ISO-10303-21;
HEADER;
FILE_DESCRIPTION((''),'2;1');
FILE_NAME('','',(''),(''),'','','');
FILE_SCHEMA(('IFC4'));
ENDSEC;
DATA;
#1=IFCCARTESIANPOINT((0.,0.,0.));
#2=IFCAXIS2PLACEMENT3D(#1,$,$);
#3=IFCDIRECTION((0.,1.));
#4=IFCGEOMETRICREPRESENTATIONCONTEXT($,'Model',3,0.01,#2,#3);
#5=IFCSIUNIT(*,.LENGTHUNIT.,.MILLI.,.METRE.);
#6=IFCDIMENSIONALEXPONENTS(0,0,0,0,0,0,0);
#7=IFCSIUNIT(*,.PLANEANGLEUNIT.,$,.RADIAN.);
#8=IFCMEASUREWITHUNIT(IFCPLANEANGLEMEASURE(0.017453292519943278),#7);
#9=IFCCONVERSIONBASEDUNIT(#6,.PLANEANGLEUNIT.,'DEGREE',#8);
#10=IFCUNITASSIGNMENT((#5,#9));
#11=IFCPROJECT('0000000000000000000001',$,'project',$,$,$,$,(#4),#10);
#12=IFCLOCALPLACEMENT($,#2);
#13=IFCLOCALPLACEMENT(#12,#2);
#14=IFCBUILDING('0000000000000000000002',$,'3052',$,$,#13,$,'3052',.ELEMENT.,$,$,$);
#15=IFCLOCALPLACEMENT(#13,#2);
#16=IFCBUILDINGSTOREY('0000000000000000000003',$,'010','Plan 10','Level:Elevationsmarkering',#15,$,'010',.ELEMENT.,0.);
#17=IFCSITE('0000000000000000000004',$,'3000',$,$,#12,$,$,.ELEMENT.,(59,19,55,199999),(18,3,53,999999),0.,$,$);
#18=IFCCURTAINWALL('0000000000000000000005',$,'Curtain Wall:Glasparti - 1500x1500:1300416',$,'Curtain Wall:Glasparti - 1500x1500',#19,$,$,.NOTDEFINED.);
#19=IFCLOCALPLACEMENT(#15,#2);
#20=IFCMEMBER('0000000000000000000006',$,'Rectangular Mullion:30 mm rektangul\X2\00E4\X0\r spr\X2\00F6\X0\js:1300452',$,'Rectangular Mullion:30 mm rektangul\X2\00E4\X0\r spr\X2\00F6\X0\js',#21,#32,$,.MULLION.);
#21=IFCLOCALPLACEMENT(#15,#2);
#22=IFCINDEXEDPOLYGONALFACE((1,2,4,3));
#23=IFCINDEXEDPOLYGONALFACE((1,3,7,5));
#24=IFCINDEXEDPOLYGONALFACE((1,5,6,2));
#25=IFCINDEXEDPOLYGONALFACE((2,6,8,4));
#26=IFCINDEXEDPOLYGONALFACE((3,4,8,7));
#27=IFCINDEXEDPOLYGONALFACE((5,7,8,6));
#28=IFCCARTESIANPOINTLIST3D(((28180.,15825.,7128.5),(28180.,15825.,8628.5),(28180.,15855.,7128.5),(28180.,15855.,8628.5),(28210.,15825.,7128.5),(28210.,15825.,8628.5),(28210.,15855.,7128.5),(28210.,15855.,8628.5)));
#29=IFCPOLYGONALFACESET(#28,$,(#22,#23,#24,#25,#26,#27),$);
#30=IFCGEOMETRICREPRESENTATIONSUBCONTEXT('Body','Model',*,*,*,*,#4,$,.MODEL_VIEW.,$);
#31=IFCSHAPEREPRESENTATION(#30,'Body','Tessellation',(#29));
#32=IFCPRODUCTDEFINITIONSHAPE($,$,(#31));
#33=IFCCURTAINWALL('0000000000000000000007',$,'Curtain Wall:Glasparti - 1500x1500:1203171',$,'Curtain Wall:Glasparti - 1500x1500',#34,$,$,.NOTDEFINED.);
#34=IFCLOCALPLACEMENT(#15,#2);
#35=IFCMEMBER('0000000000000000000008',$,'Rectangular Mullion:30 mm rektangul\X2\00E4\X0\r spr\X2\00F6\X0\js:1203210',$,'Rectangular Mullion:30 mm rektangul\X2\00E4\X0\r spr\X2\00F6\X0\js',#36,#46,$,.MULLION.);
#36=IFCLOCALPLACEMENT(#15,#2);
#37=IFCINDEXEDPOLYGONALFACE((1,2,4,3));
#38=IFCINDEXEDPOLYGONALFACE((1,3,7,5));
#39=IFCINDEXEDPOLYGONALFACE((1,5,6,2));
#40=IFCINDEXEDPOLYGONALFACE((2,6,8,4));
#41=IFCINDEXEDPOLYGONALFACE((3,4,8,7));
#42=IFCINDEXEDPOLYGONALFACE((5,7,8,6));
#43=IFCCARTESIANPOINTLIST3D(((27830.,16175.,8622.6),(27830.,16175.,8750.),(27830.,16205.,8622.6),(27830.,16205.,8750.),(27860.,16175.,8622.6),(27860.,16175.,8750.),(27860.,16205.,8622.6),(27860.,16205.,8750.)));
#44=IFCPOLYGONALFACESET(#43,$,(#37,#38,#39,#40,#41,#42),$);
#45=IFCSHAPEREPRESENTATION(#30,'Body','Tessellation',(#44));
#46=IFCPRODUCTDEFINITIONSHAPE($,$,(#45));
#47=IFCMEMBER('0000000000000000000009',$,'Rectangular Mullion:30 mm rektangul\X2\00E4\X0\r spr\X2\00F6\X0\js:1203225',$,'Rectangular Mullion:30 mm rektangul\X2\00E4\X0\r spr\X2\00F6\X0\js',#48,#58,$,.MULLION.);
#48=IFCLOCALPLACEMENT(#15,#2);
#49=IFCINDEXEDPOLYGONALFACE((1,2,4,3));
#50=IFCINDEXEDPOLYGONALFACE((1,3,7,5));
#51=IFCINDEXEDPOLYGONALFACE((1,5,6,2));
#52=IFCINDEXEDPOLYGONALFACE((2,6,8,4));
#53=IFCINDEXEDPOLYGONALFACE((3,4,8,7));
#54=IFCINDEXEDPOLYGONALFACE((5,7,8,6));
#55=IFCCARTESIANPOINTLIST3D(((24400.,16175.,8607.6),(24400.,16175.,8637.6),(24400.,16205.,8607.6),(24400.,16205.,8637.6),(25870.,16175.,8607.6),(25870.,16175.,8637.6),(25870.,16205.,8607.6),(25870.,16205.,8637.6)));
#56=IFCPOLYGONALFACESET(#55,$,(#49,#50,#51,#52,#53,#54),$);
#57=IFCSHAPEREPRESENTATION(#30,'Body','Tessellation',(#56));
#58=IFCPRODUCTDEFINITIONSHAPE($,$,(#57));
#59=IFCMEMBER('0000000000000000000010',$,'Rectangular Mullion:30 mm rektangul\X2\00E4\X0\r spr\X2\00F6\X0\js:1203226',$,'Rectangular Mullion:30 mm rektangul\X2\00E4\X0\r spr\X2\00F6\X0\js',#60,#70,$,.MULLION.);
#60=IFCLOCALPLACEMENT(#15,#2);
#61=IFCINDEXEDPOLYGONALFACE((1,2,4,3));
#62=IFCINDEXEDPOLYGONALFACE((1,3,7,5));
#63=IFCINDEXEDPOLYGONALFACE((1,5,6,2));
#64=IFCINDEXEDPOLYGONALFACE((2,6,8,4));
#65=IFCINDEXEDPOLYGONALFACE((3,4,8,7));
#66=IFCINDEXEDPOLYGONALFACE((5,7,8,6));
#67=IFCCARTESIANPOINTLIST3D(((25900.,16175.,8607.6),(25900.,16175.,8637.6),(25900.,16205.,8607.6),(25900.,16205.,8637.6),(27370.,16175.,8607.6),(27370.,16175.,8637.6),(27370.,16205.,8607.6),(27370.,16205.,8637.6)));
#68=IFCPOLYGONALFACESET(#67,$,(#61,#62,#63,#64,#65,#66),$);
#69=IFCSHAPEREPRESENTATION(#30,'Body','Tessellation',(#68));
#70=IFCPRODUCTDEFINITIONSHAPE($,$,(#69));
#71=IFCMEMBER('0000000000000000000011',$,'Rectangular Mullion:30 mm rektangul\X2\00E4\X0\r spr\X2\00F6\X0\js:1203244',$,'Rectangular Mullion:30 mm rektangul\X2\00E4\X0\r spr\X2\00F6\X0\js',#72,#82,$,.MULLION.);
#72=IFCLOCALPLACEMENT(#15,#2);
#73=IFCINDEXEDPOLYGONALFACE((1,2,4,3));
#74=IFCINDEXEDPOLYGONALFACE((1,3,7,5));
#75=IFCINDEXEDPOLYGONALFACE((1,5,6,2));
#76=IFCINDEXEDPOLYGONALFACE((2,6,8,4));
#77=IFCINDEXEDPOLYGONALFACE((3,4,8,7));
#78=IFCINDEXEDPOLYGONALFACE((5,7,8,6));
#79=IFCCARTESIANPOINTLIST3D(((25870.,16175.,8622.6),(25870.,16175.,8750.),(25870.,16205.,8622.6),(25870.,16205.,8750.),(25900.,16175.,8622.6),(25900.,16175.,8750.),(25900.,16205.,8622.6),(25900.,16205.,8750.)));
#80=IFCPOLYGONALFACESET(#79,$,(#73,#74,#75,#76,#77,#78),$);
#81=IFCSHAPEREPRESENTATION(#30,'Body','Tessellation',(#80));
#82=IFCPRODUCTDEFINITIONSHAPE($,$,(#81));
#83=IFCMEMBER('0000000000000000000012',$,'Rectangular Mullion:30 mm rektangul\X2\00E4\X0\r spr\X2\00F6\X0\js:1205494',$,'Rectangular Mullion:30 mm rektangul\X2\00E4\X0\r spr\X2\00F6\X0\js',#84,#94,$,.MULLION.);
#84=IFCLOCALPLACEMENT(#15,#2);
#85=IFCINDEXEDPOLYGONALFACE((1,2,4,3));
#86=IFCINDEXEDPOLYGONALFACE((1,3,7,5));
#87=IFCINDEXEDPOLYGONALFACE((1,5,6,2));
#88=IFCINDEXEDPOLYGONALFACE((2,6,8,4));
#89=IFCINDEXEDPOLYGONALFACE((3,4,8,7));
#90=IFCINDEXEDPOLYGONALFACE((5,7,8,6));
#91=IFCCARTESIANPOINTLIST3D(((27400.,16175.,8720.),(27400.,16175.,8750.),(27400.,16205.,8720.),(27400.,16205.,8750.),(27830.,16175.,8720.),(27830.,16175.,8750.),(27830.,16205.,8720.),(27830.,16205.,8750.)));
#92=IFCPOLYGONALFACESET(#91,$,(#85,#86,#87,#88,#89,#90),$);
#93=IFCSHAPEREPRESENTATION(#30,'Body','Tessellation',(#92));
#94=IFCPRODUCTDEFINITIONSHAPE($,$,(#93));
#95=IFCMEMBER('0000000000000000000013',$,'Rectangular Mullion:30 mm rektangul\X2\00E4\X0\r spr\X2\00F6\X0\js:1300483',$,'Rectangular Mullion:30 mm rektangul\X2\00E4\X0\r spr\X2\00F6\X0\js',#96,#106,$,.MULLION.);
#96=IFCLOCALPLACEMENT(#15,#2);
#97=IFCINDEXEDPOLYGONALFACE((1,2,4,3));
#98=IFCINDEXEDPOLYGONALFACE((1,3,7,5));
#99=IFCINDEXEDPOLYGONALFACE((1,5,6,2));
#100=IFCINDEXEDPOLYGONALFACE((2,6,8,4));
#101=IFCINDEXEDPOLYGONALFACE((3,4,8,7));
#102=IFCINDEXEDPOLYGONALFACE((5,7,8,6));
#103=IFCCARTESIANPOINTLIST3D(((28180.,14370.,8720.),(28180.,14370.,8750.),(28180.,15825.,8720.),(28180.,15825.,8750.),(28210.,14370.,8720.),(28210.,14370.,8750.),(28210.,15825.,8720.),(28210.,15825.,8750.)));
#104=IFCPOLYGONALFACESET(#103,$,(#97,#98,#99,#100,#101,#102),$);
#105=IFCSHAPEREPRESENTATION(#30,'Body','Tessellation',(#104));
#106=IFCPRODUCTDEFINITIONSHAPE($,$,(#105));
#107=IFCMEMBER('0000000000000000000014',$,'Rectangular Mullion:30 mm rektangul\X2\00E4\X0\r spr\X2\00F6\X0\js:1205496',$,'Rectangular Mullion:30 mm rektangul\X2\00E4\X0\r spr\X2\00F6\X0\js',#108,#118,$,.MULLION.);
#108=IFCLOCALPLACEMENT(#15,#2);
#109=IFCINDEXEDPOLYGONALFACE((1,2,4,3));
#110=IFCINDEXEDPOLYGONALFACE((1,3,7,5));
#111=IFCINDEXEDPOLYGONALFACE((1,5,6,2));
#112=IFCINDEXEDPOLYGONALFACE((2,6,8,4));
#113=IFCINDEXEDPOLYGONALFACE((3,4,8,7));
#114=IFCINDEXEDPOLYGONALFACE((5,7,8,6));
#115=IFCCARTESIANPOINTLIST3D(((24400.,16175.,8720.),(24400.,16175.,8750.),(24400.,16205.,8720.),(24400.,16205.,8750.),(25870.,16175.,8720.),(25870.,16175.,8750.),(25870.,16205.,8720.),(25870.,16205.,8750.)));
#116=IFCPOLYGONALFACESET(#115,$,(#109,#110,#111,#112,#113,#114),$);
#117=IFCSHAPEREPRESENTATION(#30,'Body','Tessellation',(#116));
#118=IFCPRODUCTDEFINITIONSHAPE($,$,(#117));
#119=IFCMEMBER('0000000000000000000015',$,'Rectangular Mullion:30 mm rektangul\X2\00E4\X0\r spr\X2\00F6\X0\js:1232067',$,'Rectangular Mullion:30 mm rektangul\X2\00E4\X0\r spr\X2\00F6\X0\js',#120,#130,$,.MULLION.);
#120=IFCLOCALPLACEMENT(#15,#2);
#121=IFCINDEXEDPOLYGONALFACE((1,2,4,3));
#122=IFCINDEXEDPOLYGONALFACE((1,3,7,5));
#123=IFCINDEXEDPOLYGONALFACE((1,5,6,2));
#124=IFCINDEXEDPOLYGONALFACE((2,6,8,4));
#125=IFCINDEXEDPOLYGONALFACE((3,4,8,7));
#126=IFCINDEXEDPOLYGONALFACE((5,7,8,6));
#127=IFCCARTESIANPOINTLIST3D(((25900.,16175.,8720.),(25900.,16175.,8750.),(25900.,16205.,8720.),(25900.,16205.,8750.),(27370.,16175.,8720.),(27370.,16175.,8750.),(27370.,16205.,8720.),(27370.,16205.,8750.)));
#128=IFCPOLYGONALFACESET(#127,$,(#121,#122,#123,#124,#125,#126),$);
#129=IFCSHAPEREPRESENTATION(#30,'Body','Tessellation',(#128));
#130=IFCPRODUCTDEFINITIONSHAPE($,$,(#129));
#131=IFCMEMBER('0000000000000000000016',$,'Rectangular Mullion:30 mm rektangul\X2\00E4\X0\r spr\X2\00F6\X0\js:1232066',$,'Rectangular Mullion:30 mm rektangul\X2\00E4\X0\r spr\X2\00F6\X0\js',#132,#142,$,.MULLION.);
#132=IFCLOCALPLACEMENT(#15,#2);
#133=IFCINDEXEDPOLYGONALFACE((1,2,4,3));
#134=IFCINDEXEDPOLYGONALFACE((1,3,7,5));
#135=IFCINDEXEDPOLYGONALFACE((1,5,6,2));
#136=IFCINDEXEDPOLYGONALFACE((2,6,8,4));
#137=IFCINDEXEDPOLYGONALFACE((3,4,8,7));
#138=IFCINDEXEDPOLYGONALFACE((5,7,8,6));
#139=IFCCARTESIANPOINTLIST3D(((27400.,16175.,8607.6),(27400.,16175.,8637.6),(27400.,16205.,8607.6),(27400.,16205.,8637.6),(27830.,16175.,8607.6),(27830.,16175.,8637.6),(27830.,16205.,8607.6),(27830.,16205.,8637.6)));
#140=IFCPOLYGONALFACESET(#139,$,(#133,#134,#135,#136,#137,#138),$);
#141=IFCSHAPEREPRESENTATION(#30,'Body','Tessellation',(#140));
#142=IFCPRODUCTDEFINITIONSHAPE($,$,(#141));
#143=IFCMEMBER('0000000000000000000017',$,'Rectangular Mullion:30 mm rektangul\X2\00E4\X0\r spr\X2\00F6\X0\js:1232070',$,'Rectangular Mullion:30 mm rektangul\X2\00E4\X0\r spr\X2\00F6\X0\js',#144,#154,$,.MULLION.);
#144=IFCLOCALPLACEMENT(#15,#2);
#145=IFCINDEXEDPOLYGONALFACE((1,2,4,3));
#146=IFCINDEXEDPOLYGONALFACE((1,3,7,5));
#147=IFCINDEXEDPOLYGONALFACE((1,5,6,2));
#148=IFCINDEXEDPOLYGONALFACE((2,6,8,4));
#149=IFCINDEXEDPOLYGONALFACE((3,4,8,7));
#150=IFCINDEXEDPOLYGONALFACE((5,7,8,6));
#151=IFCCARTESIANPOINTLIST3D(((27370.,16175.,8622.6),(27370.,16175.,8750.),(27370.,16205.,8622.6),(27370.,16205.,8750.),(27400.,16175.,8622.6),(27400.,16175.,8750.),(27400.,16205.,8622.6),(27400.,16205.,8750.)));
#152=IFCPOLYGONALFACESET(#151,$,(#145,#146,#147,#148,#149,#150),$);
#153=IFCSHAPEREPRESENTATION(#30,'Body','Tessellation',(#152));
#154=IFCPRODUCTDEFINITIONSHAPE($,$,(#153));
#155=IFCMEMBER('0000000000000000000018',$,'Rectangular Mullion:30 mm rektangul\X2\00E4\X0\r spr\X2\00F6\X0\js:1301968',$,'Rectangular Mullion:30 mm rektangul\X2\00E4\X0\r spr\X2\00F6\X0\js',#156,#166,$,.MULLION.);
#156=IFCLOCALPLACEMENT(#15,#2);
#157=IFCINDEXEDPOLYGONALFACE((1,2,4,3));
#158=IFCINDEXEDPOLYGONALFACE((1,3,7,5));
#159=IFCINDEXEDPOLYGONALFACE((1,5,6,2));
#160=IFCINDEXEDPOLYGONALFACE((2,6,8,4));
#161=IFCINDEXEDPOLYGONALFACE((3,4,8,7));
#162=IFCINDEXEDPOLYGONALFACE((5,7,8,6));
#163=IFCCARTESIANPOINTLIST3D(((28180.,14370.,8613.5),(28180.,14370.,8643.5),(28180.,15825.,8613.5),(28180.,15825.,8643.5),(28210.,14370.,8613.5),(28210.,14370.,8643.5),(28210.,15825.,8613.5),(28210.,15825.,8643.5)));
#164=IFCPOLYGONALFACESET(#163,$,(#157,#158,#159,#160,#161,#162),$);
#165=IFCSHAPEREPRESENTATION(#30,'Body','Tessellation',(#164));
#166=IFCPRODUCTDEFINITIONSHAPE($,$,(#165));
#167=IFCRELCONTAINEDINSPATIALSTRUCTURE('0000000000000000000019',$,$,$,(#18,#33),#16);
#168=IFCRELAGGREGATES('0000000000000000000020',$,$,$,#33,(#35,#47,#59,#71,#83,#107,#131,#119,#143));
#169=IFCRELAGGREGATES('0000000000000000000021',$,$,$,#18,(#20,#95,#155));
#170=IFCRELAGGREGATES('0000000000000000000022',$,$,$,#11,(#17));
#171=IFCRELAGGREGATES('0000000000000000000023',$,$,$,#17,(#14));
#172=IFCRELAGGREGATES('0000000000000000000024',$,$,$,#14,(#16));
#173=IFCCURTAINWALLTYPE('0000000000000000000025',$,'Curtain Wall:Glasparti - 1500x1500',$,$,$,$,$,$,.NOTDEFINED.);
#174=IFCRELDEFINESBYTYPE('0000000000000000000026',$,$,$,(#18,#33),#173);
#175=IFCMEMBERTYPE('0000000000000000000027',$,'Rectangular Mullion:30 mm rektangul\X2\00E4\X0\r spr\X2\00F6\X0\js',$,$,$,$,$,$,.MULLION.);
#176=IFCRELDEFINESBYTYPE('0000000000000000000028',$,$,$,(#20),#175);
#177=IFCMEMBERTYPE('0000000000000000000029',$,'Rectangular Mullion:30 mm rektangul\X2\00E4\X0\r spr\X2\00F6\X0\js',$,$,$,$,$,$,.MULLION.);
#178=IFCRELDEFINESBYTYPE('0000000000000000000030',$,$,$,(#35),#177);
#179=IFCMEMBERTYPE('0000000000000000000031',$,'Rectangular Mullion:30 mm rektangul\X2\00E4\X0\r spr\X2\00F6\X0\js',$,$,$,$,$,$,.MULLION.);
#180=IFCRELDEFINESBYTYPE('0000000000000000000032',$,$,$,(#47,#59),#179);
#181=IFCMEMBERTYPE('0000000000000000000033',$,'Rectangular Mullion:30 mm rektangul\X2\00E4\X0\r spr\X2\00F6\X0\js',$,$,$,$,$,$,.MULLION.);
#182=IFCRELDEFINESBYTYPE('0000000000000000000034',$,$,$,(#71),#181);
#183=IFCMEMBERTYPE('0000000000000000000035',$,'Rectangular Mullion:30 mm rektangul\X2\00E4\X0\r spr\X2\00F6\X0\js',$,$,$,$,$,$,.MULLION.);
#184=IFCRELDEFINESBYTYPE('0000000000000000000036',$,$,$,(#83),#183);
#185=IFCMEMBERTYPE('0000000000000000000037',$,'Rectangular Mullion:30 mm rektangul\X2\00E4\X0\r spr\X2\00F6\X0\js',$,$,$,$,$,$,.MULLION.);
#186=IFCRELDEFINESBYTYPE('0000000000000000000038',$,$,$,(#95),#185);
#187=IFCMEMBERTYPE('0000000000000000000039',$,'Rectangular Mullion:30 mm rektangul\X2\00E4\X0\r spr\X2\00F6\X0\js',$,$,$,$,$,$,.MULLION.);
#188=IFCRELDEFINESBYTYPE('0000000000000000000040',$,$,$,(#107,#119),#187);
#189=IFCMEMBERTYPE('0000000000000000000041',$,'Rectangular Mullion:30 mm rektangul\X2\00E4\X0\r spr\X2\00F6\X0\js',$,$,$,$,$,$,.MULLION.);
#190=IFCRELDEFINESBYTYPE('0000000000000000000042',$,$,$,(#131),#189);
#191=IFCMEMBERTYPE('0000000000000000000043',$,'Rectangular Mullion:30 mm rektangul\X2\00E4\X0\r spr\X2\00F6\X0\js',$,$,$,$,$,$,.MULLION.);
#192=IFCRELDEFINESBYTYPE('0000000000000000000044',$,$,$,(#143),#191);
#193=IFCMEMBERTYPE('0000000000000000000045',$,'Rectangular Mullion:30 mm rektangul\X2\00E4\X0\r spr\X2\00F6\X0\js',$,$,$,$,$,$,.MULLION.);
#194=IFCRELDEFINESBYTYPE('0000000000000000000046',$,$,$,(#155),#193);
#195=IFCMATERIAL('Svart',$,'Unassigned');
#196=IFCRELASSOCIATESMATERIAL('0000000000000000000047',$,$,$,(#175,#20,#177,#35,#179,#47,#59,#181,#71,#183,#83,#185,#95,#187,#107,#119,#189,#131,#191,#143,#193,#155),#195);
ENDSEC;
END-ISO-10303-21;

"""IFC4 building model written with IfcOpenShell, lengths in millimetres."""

from ifc_helpers import new_model, entity, si_unit, converted_unit, direction, frame, origin, place, context, subcontext, project, spatial, indexed_curve, outline, extrude, source, transform, mapped, material, type_object, type_shapes, element, aggregate, save


model = new_model("IFC4")

# Units and contexts
model_context = context("Model", 3, precision=0.01, world=origin(), true_north=direction((0.0, 1.0)))
body_context = subcontext(model_context, "Body", "Model", "MODEL_VIEW")
ifc_project = project(units=[si_unit("LENGTHUNIT", "METRE", prefix="MILLI"), converted_unit("PLANEANGLEUNIT", "DEGREE", entity("IfcPlaneAngleMeasure", 0.017453292519943278), si_unit("PLANEANGLEUNIT", "RADIAN"), dimensions=[0, 0, 0, 0, 0, 0, 0])], contexts=[model_context])

# Site, building, storey
site_placement = place(None, origin())
site = spatial("IfcSite", under=ifc_project, at=site_placement, Name="3000", CompositionType="ELEMENT", RefLatitude=(59, 19, 55, 199999), RefLongitude=(18, 3, 53, 999999), RefElevation=0.0)
building_placement = place(site_placement, origin())
building = spatial("IfcBuilding", under=site, at=building_placement, Name="3052", LongName="3052", CompositionType="ELEMENT")
storey_placement = place(building_placement, origin())
storey = spatial("IfcBuildingStorey", under=building, at=storey_placement, Name="010", Description="Plan 10", ObjectType="Level:Elevationsmarkering", LongName="010", CompositionType="ELEMENT", Elevation=0.0)

# Curtain wall, member
curtain_wall_type = type_object("IfcCurtainWallType", Name="Curtain Wall:Glasparti - 1500x1500", PredefinedType="NOTDEFINED")
curtain_wall_1_placement = place(storey_placement, origin())
curtain_wall_1 = element("IfcCurtainWall", 1, at=curtain_wall_1_placement, inside=storey, type_object=curtain_wall_type, Name="Curtain Wall:Glasparti - 1500x1500:1300416", ObjectType="Curtain Wall:Glasparti - 1500x1500", PredefinedType="NOTDEFINED")
ifc_material_1 = material(Name="Svart", Category="Unassigned")
member_type_1 = type_object("IfcMemberType", Name="Rectangular Mullion:30 mm rektangulär spröjs", PredefinedType="MULLION", material=ifc_material_1)
shared_shape_1 = source(origin(), body_context, "Body", "SweptSolid", [
    extrude(outline(indexed_curve([(-15.0, -15.0), (15.0, -15.0), (15.0, 15.0), (-15.0, 15.0), (-15.0, -15.0)], self_intersect=False)), frame((-15.0, 0.0, -1500.0), z_axis=(0.0, 0.0, 1.0), x_axis=(-1.0, 0.0, 0.0)), (0.0, 0.0, 1.0), 1500.0),
])
type_shapes(member_type_1, [shared_shape_1])
member_1_placement = place(curtain_wall_1_placement, frame((28195.0, 15855.0, 8628.5), z_axis=(0.0, 0.0, 1.0), x_axis=(0.0, 1.0, 0.0)))
member_1 = element("IfcMember", 2, at=member_1_placement, type_object=member_type_1, material=ifc_material_1, Name="Rectangular Mullion:30 mm rektangulär spröjs:1300452", ObjectType="Rectangular Mullion:30 mm rektangulär spröjs", PredefinedType="MULLION", context=body_context, shape_type="MappedRepresentation", body=[
    mapped(shared_shape_1, transform((0.0, 0.0, 0.0), scale=1.0)),
])

# Curtain wall, members
curtain_wall_2_placement = place(storey_placement, origin())
curtain_wall_2 = element("IfcCurtainWall", 3, at=curtain_wall_2_placement, inside=storey, type_object=curtain_wall_type, Name="Curtain Wall:Glasparti - 1500x1500:1203171", ObjectType="Curtain Wall:Glasparti - 1500x1500", PredefinedType="NOTDEFINED")
member_type_2 = type_object("IfcMemberType", Name="Rectangular Mullion:30 mm rektangulär spröjs", PredefinedType="MULLION", material=ifc_material_1)
shared_shape_2 = source(origin(), body_context, "Body", "SweptSolid", [
    extrude(outline(indexed_curve([(-15.0, -15.0), (15.0, -15.0), (15.0, 15.0), (-15.0, 15.0), (-15.0, -15.0)], self_intersect=False)), frame((-15.0, 0.0, -127.4), z_axis=(0.0, 0.0, 1.0), x_axis=(-1.0, 0.0, 0.0)), (0.0, 0.0, 1.0), 127.4),
])
type_shapes(member_type_2, [shared_shape_2])
member_2_placement = place(curtain_wall_2_placement, frame((27860.0, 16190.0, 8622.6), z_axis=(0.0, 0.0, -1.0), x_axis=(1.0, 0.0, 0.0)))
member_2 = element("IfcMember", 4, at=member_2_placement, type_object=member_type_2, material=ifc_material_1, Name="Rectangular Mullion:30 mm rektangulär spröjs:1203210", ObjectType="Rectangular Mullion:30 mm rektangulär spröjs", PredefinedType="MULLION", context=body_context, shape_type="MappedRepresentation", body=[
    mapped(shared_shape_2, transform((0.0, 0.0, 0.0), scale=1.0)),
])
member_type_3 = type_object("IfcMemberType", Name="Rectangular Mullion:30 mm rektangulär spröjs", PredefinedType="MULLION", material=ifc_material_1)
shared_shape_3 = source(origin(), body_context, "Body", "SweptSolid", [
    extrude(outline(indexed_curve([(-15.0, -15.0), (15.0, -15.0), (15.0, 15.0), (-15.0, 15.0), (-15.0, -15.0)], self_intersect=False)), frame((0.0, 0.0, -1470.0), z_axis=(0.0, 0.0, 1.0), x_axis=(-1.0, 0.0, 0.0)), (0.0, 0.0, 1.0), 1470.0),
])
type_shapes(member_type_3, [shared_shape_3])
member_3_placement = place(curtain_wall_2_placement, frame((25870.0, 16190.0, 8622.6), z_axis=(1.0, 0.0, 0.0), x_axis=(0.0, 0.0, 1.0)))
member_3 = element("IfcMember", 5, at=member_3_placement, type_object=member_type_3, material=ifc_material_1, Name="Rectangular Mullion:30 mm rektangulär spröjs:1203225", ObjectType="Rectangular Mullion:30 mm rektangulär spröjs", PredefinedType="MULLION", context=body_context, shape_type="MappedRepresentation", body=[
    mapped(shared_shape_3, transform((0.0, 0.0, 0.0), scale=1.0)),
])
member_4_placement = place(curtain_wall_2_placement, frame((27370.0, 16190.0, 8622.6), z_axis=(1.0, 0.0, 0.0), x_axis=(0.0, 0.0, 1.0)))
member_4 = element("IfcMember", 6, at=member_4_placement, type_object=member_type_3, material=ifc_material_1, Name="Rectangular Mullion:30 mm rektangulär spröjs:1203226", ObjectType="Rectangular Mullion:30 mm rektangulär spröjs", PredefinedType="MULLION", context=body_context, shape_type="MappedRepresentation", body=[
    mapped(shared_shape_3, transform((0.0, 0.0, 0.0), scale=1.0)),
])
member_type_4 = type_object("IfcMemberType", Name="Rectangular Mullion:30 mm rektangulär spröjs", PredefinedType="MULLION", material=ifc_material_1)
shared_shape_4 = source(origin(), body_context, "Body", "SweptSolid", [
    extrude(outline(indexed_curve([(-15.0, -15.0), (15.0, -15.0), (15.0, 15.0), (-15.0, 15.0), (-15.0, -15.0)], self_intersect=False)), frame((0.0, 0.0, -127.4), z_axis=(0.0, 0.0, 1.0), x_axis=(-1.0, 0.0, 0.0)), (0.0, 0.0, 1.0), 127.4),
])
type_shapes(member_type_4, [shared_shape_4])
member_5_placement = place(curtain_wall_2_placement, frame((25885.0, 16190.0, 8622.6), z_axis=(0.0, 0.0, -1.0), x_axis=(1.0, 0.0, 0.0)))
member_5 = element("IfcMember", 7, at=member_5_placement, type_object=member_type_4, material=ifc_material_1, Name="Rectangular Mullion:30 mm rektangulär spröjs:1203244", ObjectType="Rectangular Mullion:30 mm rektangulär spröjs", PredefinedType="MULLION", context=body_context, shape_type="MappedRepresentation", body=[
    mapped(shared_shape_4, transform((0.0, 0.0, 0.0), scale=1.0)),
])
member_type_5 = type_object("IfcMemberType", Name="Rectangular Mullion:30 mm rektangulär spröjs", PredefinedType="MULLION", material=ifc_material_1)
shared_shape_5 = source(origin(), body_context, "Body", "SweptSolid", [
    extrude(outline(indexed_curve([(-15.0, -15.0), (15.0, -15.0), (15.0, 15.0), (-15.0, 15.0), (-15.0, -15.0)], self_intersect=False)), frame((-15.0, 0.0, -430.0), z_axis=(0.0, 0.0, 1.0), x_axis=(-1.0, 0.0, 0.0)), (0.0, 0.0, 1.0), 430.0),
])
type_shapes(member_type_5, [shared_shape_5])
member_6_placement = place(curtain_wall_2_placement, frame((27830.0, 16190.0, 8750.0), z_axis=(1.0, 0.0, 0.0), x_axis=(0.0, 0.0, 1.0)))
member_6 = element("IfcMember", 8, at=member_6_placement, type_object=member_type_5, material=ifc_material_1, Name="Rectangular Mullion:30 mm rektangulär spröjs:1205494", ObjectType="Rectangular Mullion:30 mm rektangulär spröjs", PredefinedType="MULLION", context=body_context, shape_type="MappedRepresentation", body=[
    mapped(shared_shape_5, transform((0.0, 0.0, 0.0), scale=1.0)),
])

# Members
member_type_6 = type_object("IfcMemberType", Name="Rectangular Mullion:30 mm rektangulär spröjs", PredefinedType="MULLION", material=ifc_material_1)
shared_shape_6 = source(origin(), body_context, "Body", "SweptSolid", [
    extrude(outline(indexed_curve([(-15.0, -15.0), (15.0, -15.0), (15.0, 15.0), (-15.0, 15.0), (-15.0, -15.0)], self_intersect=False)), frame((-15.0, 0.0, -1455.0), z_axis=(0.0, 0.0, 1.0), x_axis=(-1.0, 0.0, 0.0)), (0.0, 0.0, 1.0), 1455.0),
])
type_shapes(member_type_6, [shared_shape_6])
member_7_placement = place(curtain_wall_1_placement, frame((28195.0, 14370.0, 8750.0), z_axis=(0.0, -1.0, 0.0), x_axis=(0.0, 0.0, 1.0)))
member_7 = element("IfcMember", 9, at=member_7_placement, type_object=member_type_6, material=ifc_material_1, Name="Rectangular Mullion:30 mm rektangulär spröjs:1300483", ObjectType="Rectangular Mullion:30 mm rektangulär spröjs", PredefinedType="MULLION", context=body_context, shape_type="MappedRepresentation", body=[
    mapped(shared_shape_6, transform((0.0, 0.0, 0.0), scale=1.0)),
])
member_type_7 = type_object("IfcMemberType", Name="Rectangular Mullion:30 mm rektangulär spröjs", PredefinedType="MULLION", material=ifc_material_1)
shared_shape_7 = source(origin(), body_context, "Body", "SweptSolid", [
    extrude(outline(indexed_curve([(-15.0, -15.0), (15.0, -15.0), (15.0, 15.0), (-15.0, 15.0), (-15.0, -15.0)], self_intersect=False)), frame((-15.0, 0.0, -1470.0), z_axis=(0.0, 0.0, 1.0), x_axis=(-1.0, 0.0, 0.0)), (0.0, 0.0, 1.0), 1470.0),
])
type_shapes(member_type_7, [shared_shape_7])
member_8_placement = place(curtain_wall_2_placement, frame((25870.0, 16190.0, 8750.0), z_axis=(1.0, 0.0, 0.0), x_axis=(0.0, 0.0, 1.0)))
member_8 = element("IfcMember", 10, at=member_8_placement, type_object=member_type_7, material=ifc_material_1, Name="Rectangular Mullion:30 mm rektangulär spröjs:1205496", ObjectType="Rectangular Mullion:30 mm rektangulär spröjs", PredefinedType="MULLION", context=body_context, shape_type="MappedRepresentation", body=[
    mapped(shared_shape_7, transform((0.0, 0.0, 0.0), scale=1.0)),
])
member_9_placement = place(curtain_wall_2_placement, frame((27370.0, 16190.0, 8750.0), z_axis=(1.0, 0.0, 0.0), x_axis=(0.0, 0.0, 1.0)))
member_9 = element("IfcMember", 11, at=member_9_placement, type_object=member_type_7, material=ifc_material_1, Name="Rectangular Mullion:30 mm rektangulär spröjs:1232067", ObjectType="Rectangular Mullion:30 mm rektangulär spröjs", PredefinedType="MULLION", context=body_context, shape_type="MappedRepresentation", body=[
    mapped(shared_shape_7, transform((0.0, 0.0, 0.0), scale=1.0)),
])
member_type_8 = type_object("IfcMemberType", Name="Rectangular Mullion:30 mm rektangulär spröjs", PredefinedType="MULLION", material=ifc_material_1)
shared_shape_8 = source(origin(), body_context, "Body", "SweptSolid", [
    extrude(outline(indexed_curve([(-15.0, -15.0), (15.0, -15.0), (15.0, 15.0), (-15.0, 15.0), (-15.0, -15.0)], self_intersect=False)), frame((0.0, 0.0, -430.0), z_axis=(0.0, 0.0, 1.0), x_axis=(-1.0, 0.0, 0.0)), (0.0, 0.0, 1.0), 430.0),
])
type_shapes(member_type_8, [shared_shape_8])
member_10_placement = place(curtain_wall_2_placement, frame((27830.0, 16190.0, 8622.6), z_axis=(1.0, 0.0, 0.0), x_axis=(0.0, 0.0, 1.0)))
member_10 = element("IfcMember", 12, at=member_10_placement, type_object=member_type_8, material=ifc_material_1, Name="Rectangular Mullion:30 mm rektangulär spröjs:1232066", ObjectType="Rectangular Mullion:30 mm rektangulär spröjs", PredefinedType="MULLION", context=body_context, shape_type="MappedRepresentation", body=[
    mapped(shared_shape_8, transform((0.0, 0.0, 0.0), scale=1.0)),
])
member_type_9 = type_object("IfcMemberType", Name="Rectangular Mullion:30 mm rektangulär spröjs", PredefinedType="MULLION", material=ifc_material_1)
shared_shape_9 = source(origin(), body_context, "Body", "SweptSolid", [
    extrude(outline(indexed_curve([(-15.0, -15.0), (15.0, -15.0), (15.0, 15.0), (-15.0, 15.0), (-15.0, -15.0)], self_intersect=False)), frame((0.0, 0.0, -127.4), z_axis=(0.0, 0.0, 1.0), x_axis=(-1.0, 0.0, 0.0)), (0.0, 0.0, 1.0), 127.4),
])
type_shapes(member_type_9, [shared_shape_9])
member_11_placement = place(curtain_wall_2_placement, frame((27385.0, 16190.0, 8622.6), z_axis=(0.0, 0.0, -1.0), x_axis=(1.0, 0.0, 0.0)))
member_11 = element("IfcMember", 13, at=member_11_placement, type_object=member_type_9, material=ifc_material_1, Name="Rectangular Mullion:30 mm rektangulär spröjs:1232070", ObjectType="Rectangular Mullion:30 mm rektangulär spröjs", PredefinedType="MULLION", context=body_context, shape_type="MappedRepresentation", body=[
    mapped(shared_shape_9, transform((0.0, 0.0, 0.0), scale=1.0)),
])
member_type_10 = type_object("IfcMemberType", Name="Rectangular Mullion:30 mm rektangulär spröjs", PredefinedType="MULLION", material=ifc_material_1)
shared_shape_10 = source(origin(), body_context, "Body", "SweptSolid", [
    extrude(outline(indexed_curve([(-15.0, -15.0), (15.0, -15.0), (15.0, 15.0), (-15.0, 15.0), (-15.0, -15.0)], self_intersect=False)), frame((0.0, 0.0, -1455.0), z_axis=(0.0, 0.0, 1.0), x_axis=(-1.0, 0.0, 0.0)), (0.0, 0.0, 1.0), 1455.0),
])
type_shapes(member_type_10, [shared_shape_10])
member_12_placement = place(curtain_wall_1_placement, frame((28195.0, 14370.0, 8628.5), z_axis=(0.0, -1.0, 0.0), x_axis=(0.0, 0.0, 1.0)))
member_12 = element("IfcMember", 14, at=member_12_placement, type_object=member_type_10, material=ifc_material_1, Name="Rectangular Mullion:30 mm rektangulär spröjs:1301968", ObjectType="Rectangular Mullion:30 mm rektangulär spröjs", PredefinedType="MULLION", context=body_context, shape_type="MappedRepresentation", body=[
    mapped(shared_shape_10, transform((0.0, 0.0, 0.0), scale=1.0)),
])

aggregate(curtain_wall_2, [member_2, member_3, member_4, member_5, member_6, member_8, member_10, member_9, member_11])
aggregate(curtain_wall_1, [member_1, member_7, member_12])

save(model, "model.ifc")
